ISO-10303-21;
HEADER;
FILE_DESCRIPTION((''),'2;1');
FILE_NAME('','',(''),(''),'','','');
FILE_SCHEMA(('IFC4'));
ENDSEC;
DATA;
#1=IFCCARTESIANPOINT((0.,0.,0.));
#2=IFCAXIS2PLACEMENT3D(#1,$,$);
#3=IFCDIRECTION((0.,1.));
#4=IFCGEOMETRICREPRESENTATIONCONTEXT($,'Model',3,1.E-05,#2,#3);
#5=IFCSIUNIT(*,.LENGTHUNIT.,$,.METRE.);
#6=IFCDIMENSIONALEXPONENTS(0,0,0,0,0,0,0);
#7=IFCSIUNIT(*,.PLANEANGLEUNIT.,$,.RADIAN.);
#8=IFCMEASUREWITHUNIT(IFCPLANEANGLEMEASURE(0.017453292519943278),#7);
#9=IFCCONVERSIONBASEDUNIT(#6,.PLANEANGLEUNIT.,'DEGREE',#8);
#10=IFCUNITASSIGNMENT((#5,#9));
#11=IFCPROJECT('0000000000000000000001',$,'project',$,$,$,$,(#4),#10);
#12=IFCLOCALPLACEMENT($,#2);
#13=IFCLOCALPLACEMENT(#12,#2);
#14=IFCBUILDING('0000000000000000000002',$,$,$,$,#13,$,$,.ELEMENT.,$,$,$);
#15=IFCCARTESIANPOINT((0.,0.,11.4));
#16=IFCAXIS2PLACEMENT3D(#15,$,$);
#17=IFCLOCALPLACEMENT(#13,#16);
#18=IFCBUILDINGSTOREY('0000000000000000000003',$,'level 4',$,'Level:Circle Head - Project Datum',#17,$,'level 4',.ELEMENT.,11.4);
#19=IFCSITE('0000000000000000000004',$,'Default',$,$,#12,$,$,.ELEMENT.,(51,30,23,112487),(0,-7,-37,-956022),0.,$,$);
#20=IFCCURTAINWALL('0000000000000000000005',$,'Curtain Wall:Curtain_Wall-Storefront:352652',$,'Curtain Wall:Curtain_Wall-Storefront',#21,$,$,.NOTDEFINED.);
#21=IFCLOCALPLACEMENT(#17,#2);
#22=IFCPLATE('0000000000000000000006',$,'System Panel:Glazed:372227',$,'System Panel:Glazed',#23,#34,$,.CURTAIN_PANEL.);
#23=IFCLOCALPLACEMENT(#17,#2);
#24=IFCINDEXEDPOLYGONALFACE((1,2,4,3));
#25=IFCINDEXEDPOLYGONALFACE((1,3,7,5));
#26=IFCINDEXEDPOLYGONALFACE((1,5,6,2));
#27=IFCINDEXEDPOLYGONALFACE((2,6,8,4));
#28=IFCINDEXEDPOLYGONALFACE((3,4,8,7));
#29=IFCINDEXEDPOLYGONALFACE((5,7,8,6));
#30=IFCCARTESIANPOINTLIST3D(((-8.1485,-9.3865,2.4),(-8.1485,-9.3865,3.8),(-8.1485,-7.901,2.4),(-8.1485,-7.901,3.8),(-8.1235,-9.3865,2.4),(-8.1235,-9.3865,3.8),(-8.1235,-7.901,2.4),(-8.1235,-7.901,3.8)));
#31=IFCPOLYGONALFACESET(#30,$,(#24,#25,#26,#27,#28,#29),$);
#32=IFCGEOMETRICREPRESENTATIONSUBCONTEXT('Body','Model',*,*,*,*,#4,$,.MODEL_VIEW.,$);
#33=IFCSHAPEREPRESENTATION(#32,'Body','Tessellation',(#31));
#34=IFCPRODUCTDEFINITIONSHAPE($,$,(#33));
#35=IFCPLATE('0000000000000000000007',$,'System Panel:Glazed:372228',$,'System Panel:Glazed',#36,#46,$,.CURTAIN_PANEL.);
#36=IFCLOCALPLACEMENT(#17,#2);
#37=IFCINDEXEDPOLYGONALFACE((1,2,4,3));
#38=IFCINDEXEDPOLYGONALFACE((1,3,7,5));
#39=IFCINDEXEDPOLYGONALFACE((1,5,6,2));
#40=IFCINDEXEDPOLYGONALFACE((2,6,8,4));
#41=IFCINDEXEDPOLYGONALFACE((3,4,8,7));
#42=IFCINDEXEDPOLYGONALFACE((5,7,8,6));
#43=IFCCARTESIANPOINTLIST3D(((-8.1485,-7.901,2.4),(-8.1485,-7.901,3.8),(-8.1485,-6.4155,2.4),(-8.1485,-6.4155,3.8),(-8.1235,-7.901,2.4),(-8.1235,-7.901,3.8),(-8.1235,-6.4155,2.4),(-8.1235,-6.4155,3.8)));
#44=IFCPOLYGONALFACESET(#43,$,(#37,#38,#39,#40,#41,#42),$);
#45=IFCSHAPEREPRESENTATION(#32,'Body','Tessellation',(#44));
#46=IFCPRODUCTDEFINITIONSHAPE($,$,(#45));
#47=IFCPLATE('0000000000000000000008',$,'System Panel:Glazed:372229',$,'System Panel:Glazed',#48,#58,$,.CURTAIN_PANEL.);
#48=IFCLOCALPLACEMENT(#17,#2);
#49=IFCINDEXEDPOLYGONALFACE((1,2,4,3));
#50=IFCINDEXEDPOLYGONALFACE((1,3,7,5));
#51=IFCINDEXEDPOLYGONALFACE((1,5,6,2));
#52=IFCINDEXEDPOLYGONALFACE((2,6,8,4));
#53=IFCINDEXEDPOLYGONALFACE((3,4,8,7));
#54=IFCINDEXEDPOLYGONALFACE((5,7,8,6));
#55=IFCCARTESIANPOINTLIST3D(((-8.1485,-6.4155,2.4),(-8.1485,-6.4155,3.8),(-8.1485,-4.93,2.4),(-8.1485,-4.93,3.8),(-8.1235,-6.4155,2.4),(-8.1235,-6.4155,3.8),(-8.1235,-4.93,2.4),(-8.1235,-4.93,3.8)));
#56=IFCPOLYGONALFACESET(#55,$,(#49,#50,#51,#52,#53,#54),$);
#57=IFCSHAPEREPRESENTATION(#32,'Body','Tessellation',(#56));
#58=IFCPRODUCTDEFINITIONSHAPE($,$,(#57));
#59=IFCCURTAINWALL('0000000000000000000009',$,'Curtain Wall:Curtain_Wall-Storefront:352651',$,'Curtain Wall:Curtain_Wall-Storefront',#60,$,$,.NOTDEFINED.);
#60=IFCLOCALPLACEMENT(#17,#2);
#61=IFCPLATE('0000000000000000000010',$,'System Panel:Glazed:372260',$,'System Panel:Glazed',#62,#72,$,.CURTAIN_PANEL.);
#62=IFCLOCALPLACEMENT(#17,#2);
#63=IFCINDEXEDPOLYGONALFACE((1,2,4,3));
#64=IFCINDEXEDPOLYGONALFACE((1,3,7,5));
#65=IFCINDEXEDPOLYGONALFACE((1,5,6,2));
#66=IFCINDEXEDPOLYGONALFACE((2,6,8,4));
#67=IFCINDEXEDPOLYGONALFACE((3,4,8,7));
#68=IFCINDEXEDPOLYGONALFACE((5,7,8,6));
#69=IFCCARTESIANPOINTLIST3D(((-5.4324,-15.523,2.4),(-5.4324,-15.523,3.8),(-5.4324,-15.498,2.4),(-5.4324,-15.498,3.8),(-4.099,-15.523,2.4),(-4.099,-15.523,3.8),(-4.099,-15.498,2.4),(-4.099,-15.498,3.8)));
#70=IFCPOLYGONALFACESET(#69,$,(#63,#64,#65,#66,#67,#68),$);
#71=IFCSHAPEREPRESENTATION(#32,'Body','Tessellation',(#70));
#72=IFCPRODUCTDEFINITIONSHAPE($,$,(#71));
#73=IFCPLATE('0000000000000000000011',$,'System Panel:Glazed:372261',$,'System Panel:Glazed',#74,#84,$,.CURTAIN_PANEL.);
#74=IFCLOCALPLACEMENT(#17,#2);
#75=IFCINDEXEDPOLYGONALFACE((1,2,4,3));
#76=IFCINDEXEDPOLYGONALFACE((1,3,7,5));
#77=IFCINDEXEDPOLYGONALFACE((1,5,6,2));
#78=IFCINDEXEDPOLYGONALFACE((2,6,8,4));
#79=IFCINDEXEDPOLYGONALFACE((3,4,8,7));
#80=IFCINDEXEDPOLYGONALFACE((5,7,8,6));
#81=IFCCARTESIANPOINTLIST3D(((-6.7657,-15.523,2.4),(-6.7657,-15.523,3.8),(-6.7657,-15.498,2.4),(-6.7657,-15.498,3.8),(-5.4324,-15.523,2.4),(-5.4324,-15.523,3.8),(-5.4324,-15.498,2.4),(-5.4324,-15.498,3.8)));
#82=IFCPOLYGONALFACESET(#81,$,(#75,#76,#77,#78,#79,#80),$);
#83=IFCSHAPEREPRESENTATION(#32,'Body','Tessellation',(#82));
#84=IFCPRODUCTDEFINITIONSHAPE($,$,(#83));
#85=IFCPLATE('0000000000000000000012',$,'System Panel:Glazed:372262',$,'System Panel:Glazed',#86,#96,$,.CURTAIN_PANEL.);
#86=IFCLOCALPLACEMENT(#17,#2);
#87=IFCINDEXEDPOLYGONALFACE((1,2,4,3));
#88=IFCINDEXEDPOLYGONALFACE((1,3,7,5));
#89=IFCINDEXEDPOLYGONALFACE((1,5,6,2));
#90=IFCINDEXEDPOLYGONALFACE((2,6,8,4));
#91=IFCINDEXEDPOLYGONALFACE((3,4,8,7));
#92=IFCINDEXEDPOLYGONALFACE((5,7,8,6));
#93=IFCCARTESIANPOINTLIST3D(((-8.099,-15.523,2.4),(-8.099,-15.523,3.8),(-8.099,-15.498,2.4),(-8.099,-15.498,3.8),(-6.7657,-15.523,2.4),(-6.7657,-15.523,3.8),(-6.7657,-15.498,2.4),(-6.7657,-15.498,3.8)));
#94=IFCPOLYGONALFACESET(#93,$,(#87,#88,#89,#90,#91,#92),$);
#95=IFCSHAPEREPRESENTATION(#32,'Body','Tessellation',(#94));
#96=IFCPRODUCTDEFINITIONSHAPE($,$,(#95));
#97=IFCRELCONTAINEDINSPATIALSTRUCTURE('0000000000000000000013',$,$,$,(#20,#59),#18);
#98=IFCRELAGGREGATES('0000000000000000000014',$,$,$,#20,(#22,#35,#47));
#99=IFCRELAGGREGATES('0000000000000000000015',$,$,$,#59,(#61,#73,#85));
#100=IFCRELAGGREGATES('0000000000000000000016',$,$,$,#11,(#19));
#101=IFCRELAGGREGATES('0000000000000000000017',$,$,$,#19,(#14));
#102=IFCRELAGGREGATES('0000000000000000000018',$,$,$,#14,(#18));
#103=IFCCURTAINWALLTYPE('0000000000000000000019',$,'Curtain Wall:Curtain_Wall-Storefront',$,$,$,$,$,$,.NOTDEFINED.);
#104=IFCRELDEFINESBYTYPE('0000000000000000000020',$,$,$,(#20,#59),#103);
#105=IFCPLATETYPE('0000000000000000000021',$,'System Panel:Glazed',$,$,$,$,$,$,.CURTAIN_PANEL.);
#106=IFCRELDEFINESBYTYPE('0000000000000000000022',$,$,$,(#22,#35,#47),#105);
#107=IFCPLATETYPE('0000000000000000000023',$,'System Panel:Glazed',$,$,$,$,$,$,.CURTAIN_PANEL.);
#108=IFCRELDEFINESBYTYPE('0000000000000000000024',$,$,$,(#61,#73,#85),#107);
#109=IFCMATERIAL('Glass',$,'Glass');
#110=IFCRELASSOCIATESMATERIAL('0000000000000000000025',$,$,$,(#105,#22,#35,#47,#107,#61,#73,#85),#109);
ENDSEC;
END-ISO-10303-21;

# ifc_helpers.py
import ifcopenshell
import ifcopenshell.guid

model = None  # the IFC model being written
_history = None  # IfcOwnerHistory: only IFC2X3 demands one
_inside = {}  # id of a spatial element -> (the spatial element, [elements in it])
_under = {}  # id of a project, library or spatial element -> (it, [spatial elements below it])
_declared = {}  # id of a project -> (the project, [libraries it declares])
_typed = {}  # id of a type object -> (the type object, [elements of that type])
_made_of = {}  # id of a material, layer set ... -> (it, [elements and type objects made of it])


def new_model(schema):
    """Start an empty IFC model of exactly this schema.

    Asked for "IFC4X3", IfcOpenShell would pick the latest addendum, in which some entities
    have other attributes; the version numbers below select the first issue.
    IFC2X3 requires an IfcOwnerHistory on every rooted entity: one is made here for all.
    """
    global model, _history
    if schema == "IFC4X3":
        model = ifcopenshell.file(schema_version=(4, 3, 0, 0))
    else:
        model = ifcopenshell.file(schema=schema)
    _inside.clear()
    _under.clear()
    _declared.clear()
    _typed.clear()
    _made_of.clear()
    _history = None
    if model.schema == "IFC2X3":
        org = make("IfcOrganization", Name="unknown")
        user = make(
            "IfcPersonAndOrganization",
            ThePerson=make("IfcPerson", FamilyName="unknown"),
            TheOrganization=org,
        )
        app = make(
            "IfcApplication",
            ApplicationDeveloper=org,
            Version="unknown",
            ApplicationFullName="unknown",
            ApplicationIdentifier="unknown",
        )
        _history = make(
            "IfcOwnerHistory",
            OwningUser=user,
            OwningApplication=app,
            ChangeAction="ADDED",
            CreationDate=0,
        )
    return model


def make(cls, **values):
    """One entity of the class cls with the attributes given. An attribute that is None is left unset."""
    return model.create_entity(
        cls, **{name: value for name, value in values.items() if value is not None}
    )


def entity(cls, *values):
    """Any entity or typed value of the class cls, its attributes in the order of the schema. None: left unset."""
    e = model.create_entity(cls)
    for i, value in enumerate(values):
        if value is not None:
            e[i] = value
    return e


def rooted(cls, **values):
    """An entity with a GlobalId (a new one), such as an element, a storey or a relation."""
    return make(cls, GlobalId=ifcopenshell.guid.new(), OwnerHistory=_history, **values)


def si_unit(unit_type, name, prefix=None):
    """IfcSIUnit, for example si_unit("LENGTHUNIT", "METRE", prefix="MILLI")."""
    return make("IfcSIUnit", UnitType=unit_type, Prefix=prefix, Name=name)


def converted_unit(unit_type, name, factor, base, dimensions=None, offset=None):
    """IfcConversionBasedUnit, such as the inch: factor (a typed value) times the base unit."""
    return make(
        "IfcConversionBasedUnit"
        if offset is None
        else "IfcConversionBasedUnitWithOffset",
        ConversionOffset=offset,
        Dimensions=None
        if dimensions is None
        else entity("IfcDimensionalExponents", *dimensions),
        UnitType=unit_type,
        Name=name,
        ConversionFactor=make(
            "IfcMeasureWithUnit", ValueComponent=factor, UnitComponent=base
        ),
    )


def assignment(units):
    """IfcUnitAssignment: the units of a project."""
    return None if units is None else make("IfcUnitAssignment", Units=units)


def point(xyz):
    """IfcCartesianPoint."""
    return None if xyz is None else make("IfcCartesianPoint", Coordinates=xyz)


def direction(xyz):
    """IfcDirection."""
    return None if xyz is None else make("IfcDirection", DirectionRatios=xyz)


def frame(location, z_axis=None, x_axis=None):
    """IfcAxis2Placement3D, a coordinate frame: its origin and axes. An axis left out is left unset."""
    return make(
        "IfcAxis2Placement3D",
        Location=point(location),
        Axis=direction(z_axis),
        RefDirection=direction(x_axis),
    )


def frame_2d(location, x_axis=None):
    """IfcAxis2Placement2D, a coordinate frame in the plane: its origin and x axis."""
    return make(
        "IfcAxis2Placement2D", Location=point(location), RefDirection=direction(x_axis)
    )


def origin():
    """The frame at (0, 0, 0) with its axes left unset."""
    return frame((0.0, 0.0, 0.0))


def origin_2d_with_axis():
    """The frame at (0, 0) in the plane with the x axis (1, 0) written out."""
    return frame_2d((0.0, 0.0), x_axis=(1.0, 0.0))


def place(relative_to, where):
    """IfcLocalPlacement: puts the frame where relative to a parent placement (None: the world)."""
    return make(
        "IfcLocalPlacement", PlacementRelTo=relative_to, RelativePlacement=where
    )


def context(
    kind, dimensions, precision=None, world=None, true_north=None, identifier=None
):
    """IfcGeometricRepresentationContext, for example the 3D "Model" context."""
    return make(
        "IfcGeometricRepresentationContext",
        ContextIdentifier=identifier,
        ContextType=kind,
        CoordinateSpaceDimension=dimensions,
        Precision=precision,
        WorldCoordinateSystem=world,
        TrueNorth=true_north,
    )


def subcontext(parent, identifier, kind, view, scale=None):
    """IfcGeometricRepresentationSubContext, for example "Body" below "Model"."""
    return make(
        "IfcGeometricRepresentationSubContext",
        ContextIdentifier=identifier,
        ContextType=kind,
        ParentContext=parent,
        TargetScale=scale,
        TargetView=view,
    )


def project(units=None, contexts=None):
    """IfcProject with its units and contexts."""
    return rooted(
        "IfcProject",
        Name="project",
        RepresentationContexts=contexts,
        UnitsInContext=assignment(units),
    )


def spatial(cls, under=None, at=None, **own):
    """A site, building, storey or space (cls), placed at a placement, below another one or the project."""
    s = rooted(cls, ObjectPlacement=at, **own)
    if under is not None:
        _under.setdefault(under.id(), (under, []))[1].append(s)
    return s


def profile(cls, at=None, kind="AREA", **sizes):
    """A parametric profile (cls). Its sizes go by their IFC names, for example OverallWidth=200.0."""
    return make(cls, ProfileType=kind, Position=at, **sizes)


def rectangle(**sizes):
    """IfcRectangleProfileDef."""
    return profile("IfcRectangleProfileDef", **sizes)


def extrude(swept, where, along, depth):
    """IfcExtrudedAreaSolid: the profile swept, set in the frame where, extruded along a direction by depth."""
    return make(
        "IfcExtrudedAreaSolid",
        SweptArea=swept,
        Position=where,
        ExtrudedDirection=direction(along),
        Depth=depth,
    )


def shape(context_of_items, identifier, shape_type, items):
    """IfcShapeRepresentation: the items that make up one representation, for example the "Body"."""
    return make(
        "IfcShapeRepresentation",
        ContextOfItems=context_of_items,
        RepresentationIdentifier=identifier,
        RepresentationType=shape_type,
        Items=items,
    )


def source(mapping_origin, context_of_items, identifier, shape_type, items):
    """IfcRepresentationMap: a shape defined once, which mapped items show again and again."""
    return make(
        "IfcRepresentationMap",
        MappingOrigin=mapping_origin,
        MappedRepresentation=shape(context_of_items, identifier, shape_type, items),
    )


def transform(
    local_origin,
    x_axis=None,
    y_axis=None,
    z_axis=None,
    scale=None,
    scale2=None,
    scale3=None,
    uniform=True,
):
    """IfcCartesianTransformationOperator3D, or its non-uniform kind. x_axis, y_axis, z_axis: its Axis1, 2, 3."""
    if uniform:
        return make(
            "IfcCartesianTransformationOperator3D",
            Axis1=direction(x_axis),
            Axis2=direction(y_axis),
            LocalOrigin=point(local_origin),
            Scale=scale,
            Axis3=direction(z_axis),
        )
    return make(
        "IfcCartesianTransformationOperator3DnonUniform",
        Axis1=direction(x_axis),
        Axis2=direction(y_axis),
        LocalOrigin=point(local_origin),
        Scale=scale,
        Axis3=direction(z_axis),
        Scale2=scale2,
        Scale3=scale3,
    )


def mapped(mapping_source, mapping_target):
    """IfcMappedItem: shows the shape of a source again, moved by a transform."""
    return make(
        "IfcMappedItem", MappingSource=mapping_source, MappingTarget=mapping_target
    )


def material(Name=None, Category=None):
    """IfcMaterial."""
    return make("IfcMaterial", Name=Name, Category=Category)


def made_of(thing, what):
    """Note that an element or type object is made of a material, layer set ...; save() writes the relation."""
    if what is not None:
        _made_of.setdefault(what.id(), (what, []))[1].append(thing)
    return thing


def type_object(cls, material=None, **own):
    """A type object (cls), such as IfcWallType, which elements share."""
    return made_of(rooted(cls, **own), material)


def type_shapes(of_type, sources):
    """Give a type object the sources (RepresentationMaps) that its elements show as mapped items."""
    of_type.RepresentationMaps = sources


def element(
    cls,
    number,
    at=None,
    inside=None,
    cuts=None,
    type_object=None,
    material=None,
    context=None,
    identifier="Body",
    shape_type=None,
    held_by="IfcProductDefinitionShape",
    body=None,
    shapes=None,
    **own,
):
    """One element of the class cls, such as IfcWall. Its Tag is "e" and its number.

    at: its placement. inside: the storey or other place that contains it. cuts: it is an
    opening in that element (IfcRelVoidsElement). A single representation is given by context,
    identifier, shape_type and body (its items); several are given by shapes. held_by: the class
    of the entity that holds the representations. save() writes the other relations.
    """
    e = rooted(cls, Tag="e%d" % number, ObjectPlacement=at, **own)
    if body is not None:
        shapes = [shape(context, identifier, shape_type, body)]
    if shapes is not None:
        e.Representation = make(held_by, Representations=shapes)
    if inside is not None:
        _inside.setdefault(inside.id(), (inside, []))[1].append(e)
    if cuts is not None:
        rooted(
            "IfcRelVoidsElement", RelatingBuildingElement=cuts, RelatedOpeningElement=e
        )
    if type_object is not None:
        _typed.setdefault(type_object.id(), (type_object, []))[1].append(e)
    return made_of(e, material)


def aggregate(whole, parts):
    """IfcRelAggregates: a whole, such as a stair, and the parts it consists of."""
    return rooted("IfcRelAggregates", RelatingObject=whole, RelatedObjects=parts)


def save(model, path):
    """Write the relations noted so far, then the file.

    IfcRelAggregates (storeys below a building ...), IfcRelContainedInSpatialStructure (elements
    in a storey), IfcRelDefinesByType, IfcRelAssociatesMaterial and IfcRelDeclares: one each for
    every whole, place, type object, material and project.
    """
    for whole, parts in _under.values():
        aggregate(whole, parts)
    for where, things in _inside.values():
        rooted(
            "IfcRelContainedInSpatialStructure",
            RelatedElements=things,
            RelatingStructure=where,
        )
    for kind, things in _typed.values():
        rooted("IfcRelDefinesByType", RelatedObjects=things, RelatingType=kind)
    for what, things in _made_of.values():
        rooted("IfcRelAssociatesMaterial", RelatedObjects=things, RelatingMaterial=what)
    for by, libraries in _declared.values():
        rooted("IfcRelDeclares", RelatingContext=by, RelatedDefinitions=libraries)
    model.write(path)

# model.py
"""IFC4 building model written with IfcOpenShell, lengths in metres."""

from ifc_helpers import new_model, entity, si_unit, converted_unit, direction, frame, origin, origin_2d_with_axis, place, context, subcontext, project, spatial, rectangle, extrude, source, transform, mapped, material, type_object, type_shapes, element, aggregate, save


model = new_model("IFC4")

# Units and contexts
model_context = context("Model", 3, precision=1e-05, world=origin(), true_north=direction((0.0, 1.0)))
body_context = subcontext(model_context, "Body", "Model", "MODEL_VIEW")
ifc_project = project(units=[si_unit("LENGTHUNIT", "METRE"), converted_unit("PLANEANGLEUNIT", "DEGREE", entity("IfcPlaneAngleMeasure", 0.017453292519943278), si_unit("PLANEANGLEUNIT", "RADIAN"), dimensions=[0, 0, 0, 0, 0, 0, 0])], contexts=[model_context])

# Site, building, storey
site_placement = place(None, origin())
site = spatial("IfcSite", under=ifc_project, at=site_placement, Name="Default", CompositionType="ELEMENT", RefLatitude=(51, 30, 23, 112487), RefLongitude=(0, -7, -37, -956022), RefElevation=0.0)
building_placement = place(site_placement, origin())
building = spatial("IfcBuilding", under=site, at=building_placement, CompositionType="ELEMENT")
storey_placement = place(building_placement, frame((0.0, 0.0, 11.4)))
storey = spatial("IfcBuildingStorey", under=building, at=storey_placement, Name="level 4", ObjectType="Level:Circle Head - Project Datum", LongName="level 4", CompositionType="ELEMENT", Elevation=11.4)

# Curtain wall
curtain_wall_type = type_object("IfcCurtainWallType", Name="Curtain Wall:Curtain_Wall-Storefront", PredefinedType="NOTDEFINED")
ifc_material = material(Name="Glass", Category="Glass")
curtain_wall_1_placement = place(storey_placement, frame((0.0, 0.0, -11.4)))
curtain_wall_1 = element("IfcCurtainWall", 1, at=curtain_wall_1_placement, inside=storey, type_object=curtain_wall_type, Name="Curtain Wall:Curtain_Wall-Storefront:352652", ObjectType="Curtain Wall:Curtain_Wall-Storefront", PredefinedType="NOTDEFINED")

# Plates
plate_type_1 = type_object("IfcPlateType", Name="System Panel:Glazed", PredefinedType="CURTAIN_PANEL", material=ifc_material)
shared_shape_1 = source(origin(), body_context, "Body", "SweptSolid", [
    extrude(rectangle(XDim=0.025, YDim=1.4855, at=origin_2d_with_axis()), frame((0.7428, 0.0125, 0.0), z_axis=(0.0, 0.0, 1.0), x_axis=(0.0, 1.0, 0.0)), (0.0, 0.0, 1.0), 1.4),
])
type_shapes(plate_type_1, [shared_shape_1])
plate_1_placement = place(curtain_wall_1_placement, frame((-8.1235, -9.3865, 13.8), z_axis=(0.0, 0.0, 1.0), x_axis=(0.0, 1.0, 0.0)))
plate_1 = element("IfcPlate", 2, at=plate_1_placement, type_object=plate_type_1, material=ifc_material, Name="System Panel:Glazed:372227", ObjectType="System Panel:Glazed", PredefinedType="CURTAIN_PANEL", context=body_context, shape_type="MappedRepresentation", body=[
    mapped(shared_shape_1, transform((0.0, 0.0, 0.0), scale=1.0)),
])
plate_2_placement = place(curtain_wall_1_placement, frame((-8.1235, -7.901, 13.8), z_axis=(0.0, 0.0, 1.0), x_axis=(0.0, 1.0, 0.0)))
plate_2 = element("IfcPlate", 3, at=plate_2_placement, type_object=plate_type_1, material=ifc_material, Name="System Panel:Glazed:372228", ObjectType="System Panel:Glazed", PredefinedType="CURTAIN_PANEL", context=body_context, shape_type="MappedRepresentation", body=[
    mapped(shared_shape_1, transform((0.0, 0.0, 0.0), scale=1.0)),
])
plate_3_placement = place(curtain_wall_1_placement, frame((-8.1235, -6.4155, 13.8), z_axis=(0.0, 0.0, 1.0), x_axis=(0.0, 1.0, 0.0)))
plate_3 = element("IfcPlate", 4, at=plate_3_placement, type_object=plate_type_1, material=ifc_material, Name="System Panel:Glazed:372229", ObjectType="System Panel:Glazed", PredefinedType="CURTAIN_PANEL", context=body_context, shape_type="MappedRepresentation", body=[
    mapped(shared_shape_1, transform((0.0, 0.0, 0.0), scale=1.0)),
])
aggregate(curtain_wall_1, [plate_1, plate_2, plate_3])

# Curtain wall, plates
curtain_wall_2_placement = place(storey_placement, frame((0.0, 0.0, -11.4)))
curtain_wall_2 = element("IfcCurtainWall", 5, at=curtain_wall_2_placement, inside=storey, type_object=curtain_wall_type, Name="Curtain Wall:Curtain_Wall-Storefront:352651", ObjectType="Curtain Wall:Curtain_Wall-Storefront", PredefinedType="NOTDEFINED")
plate_type_2 = type_object("IfcPlateType", Name="System Panel:Glazed", PredefinedType="CURTAIN_PANEL", material=ifc_material)
shared_shape_2 = source(origin(), body_context, "Body", "SweptSolid", [
    extrude(rectangle(XDim=0.025, YDim=1.3333, at=origin_2d_with_axis()), frame((0.6667, 0.0125, 0.0), z_axis=(0.0, 0.0, 1.0), x_axis=(0.0, 1.0, 0.0)), (0.0, 0.0, 1.0), 1.4),
])
type_shapes(plate_type_2, [shared_shape_2])
plate_4_placement = place(curtain_wall_2_placement, frame((-4.099, -15.498, 13.8), z_axis=(0.0, 0.0, 1.0), x_axis=(-1.0, 0.0, 0.0)))
plate_4 = element("IfcPlate", 6, at=plate_4_placement, type_object=plate_type_2, material=ifc_material, Name="System Panel:Glazed:372260", ObjectType="System Panel:Glazed", PredefinedType="CURTAIN_PANEL", context=body_context, shape_type="MappedRepresentation", body=[
    mapped(shared_shape_2, transform((0.0, 0.0, 0.0), scale=1.0)),
])
plate_5_placement = place(curtain_wall_2_placement, frame((-5.4324, -15.498, 13.8), z_axis=(0.0, 0.0, 1.0), x_axis=(-1.0, 0.0, 0.0)))
plate_5 = element("IfcPlate", 7, at=plate_5_placement, type_object=plate_type_2, material=ifc_material, Name="System Panel:Glazed:372261", ObjectType="System Panel:Glazed", PredefinedType="CURTAIN_PANEL", context=body_context, shape_type="MappedRepresentation", body=[
    mapped(shared_shape_2, transform((0.0, 0.0, 0.0), scale=1.0)),
])
plate_6_placement = place(curtain_wall_2_placement, frame((-6.7657, -15.498, 13.8), z_axis=(0.0, 0.0, 1.0), x_axis=(-1.0, 0.0, 0.0)))
plate_6 = element("IfcPlate", 8, at=plate_6_placement, type_object=plate_type_2, material=ifc_material, Name="System Panel:Glazed:372262", ObjectType="System Panel:Glazed", PredefinedType="CURTAIN_PANEL", context=body_context, shape_type="MappedRepresentation", body=[
    mapped(shared_shape_2, transform((0.0, 0.0, 0.0), scale=1.0)),
])
aggregate(curtain_wall_2, [plate_4, plate_5, plate_6])

save(model, "model.ifc")
